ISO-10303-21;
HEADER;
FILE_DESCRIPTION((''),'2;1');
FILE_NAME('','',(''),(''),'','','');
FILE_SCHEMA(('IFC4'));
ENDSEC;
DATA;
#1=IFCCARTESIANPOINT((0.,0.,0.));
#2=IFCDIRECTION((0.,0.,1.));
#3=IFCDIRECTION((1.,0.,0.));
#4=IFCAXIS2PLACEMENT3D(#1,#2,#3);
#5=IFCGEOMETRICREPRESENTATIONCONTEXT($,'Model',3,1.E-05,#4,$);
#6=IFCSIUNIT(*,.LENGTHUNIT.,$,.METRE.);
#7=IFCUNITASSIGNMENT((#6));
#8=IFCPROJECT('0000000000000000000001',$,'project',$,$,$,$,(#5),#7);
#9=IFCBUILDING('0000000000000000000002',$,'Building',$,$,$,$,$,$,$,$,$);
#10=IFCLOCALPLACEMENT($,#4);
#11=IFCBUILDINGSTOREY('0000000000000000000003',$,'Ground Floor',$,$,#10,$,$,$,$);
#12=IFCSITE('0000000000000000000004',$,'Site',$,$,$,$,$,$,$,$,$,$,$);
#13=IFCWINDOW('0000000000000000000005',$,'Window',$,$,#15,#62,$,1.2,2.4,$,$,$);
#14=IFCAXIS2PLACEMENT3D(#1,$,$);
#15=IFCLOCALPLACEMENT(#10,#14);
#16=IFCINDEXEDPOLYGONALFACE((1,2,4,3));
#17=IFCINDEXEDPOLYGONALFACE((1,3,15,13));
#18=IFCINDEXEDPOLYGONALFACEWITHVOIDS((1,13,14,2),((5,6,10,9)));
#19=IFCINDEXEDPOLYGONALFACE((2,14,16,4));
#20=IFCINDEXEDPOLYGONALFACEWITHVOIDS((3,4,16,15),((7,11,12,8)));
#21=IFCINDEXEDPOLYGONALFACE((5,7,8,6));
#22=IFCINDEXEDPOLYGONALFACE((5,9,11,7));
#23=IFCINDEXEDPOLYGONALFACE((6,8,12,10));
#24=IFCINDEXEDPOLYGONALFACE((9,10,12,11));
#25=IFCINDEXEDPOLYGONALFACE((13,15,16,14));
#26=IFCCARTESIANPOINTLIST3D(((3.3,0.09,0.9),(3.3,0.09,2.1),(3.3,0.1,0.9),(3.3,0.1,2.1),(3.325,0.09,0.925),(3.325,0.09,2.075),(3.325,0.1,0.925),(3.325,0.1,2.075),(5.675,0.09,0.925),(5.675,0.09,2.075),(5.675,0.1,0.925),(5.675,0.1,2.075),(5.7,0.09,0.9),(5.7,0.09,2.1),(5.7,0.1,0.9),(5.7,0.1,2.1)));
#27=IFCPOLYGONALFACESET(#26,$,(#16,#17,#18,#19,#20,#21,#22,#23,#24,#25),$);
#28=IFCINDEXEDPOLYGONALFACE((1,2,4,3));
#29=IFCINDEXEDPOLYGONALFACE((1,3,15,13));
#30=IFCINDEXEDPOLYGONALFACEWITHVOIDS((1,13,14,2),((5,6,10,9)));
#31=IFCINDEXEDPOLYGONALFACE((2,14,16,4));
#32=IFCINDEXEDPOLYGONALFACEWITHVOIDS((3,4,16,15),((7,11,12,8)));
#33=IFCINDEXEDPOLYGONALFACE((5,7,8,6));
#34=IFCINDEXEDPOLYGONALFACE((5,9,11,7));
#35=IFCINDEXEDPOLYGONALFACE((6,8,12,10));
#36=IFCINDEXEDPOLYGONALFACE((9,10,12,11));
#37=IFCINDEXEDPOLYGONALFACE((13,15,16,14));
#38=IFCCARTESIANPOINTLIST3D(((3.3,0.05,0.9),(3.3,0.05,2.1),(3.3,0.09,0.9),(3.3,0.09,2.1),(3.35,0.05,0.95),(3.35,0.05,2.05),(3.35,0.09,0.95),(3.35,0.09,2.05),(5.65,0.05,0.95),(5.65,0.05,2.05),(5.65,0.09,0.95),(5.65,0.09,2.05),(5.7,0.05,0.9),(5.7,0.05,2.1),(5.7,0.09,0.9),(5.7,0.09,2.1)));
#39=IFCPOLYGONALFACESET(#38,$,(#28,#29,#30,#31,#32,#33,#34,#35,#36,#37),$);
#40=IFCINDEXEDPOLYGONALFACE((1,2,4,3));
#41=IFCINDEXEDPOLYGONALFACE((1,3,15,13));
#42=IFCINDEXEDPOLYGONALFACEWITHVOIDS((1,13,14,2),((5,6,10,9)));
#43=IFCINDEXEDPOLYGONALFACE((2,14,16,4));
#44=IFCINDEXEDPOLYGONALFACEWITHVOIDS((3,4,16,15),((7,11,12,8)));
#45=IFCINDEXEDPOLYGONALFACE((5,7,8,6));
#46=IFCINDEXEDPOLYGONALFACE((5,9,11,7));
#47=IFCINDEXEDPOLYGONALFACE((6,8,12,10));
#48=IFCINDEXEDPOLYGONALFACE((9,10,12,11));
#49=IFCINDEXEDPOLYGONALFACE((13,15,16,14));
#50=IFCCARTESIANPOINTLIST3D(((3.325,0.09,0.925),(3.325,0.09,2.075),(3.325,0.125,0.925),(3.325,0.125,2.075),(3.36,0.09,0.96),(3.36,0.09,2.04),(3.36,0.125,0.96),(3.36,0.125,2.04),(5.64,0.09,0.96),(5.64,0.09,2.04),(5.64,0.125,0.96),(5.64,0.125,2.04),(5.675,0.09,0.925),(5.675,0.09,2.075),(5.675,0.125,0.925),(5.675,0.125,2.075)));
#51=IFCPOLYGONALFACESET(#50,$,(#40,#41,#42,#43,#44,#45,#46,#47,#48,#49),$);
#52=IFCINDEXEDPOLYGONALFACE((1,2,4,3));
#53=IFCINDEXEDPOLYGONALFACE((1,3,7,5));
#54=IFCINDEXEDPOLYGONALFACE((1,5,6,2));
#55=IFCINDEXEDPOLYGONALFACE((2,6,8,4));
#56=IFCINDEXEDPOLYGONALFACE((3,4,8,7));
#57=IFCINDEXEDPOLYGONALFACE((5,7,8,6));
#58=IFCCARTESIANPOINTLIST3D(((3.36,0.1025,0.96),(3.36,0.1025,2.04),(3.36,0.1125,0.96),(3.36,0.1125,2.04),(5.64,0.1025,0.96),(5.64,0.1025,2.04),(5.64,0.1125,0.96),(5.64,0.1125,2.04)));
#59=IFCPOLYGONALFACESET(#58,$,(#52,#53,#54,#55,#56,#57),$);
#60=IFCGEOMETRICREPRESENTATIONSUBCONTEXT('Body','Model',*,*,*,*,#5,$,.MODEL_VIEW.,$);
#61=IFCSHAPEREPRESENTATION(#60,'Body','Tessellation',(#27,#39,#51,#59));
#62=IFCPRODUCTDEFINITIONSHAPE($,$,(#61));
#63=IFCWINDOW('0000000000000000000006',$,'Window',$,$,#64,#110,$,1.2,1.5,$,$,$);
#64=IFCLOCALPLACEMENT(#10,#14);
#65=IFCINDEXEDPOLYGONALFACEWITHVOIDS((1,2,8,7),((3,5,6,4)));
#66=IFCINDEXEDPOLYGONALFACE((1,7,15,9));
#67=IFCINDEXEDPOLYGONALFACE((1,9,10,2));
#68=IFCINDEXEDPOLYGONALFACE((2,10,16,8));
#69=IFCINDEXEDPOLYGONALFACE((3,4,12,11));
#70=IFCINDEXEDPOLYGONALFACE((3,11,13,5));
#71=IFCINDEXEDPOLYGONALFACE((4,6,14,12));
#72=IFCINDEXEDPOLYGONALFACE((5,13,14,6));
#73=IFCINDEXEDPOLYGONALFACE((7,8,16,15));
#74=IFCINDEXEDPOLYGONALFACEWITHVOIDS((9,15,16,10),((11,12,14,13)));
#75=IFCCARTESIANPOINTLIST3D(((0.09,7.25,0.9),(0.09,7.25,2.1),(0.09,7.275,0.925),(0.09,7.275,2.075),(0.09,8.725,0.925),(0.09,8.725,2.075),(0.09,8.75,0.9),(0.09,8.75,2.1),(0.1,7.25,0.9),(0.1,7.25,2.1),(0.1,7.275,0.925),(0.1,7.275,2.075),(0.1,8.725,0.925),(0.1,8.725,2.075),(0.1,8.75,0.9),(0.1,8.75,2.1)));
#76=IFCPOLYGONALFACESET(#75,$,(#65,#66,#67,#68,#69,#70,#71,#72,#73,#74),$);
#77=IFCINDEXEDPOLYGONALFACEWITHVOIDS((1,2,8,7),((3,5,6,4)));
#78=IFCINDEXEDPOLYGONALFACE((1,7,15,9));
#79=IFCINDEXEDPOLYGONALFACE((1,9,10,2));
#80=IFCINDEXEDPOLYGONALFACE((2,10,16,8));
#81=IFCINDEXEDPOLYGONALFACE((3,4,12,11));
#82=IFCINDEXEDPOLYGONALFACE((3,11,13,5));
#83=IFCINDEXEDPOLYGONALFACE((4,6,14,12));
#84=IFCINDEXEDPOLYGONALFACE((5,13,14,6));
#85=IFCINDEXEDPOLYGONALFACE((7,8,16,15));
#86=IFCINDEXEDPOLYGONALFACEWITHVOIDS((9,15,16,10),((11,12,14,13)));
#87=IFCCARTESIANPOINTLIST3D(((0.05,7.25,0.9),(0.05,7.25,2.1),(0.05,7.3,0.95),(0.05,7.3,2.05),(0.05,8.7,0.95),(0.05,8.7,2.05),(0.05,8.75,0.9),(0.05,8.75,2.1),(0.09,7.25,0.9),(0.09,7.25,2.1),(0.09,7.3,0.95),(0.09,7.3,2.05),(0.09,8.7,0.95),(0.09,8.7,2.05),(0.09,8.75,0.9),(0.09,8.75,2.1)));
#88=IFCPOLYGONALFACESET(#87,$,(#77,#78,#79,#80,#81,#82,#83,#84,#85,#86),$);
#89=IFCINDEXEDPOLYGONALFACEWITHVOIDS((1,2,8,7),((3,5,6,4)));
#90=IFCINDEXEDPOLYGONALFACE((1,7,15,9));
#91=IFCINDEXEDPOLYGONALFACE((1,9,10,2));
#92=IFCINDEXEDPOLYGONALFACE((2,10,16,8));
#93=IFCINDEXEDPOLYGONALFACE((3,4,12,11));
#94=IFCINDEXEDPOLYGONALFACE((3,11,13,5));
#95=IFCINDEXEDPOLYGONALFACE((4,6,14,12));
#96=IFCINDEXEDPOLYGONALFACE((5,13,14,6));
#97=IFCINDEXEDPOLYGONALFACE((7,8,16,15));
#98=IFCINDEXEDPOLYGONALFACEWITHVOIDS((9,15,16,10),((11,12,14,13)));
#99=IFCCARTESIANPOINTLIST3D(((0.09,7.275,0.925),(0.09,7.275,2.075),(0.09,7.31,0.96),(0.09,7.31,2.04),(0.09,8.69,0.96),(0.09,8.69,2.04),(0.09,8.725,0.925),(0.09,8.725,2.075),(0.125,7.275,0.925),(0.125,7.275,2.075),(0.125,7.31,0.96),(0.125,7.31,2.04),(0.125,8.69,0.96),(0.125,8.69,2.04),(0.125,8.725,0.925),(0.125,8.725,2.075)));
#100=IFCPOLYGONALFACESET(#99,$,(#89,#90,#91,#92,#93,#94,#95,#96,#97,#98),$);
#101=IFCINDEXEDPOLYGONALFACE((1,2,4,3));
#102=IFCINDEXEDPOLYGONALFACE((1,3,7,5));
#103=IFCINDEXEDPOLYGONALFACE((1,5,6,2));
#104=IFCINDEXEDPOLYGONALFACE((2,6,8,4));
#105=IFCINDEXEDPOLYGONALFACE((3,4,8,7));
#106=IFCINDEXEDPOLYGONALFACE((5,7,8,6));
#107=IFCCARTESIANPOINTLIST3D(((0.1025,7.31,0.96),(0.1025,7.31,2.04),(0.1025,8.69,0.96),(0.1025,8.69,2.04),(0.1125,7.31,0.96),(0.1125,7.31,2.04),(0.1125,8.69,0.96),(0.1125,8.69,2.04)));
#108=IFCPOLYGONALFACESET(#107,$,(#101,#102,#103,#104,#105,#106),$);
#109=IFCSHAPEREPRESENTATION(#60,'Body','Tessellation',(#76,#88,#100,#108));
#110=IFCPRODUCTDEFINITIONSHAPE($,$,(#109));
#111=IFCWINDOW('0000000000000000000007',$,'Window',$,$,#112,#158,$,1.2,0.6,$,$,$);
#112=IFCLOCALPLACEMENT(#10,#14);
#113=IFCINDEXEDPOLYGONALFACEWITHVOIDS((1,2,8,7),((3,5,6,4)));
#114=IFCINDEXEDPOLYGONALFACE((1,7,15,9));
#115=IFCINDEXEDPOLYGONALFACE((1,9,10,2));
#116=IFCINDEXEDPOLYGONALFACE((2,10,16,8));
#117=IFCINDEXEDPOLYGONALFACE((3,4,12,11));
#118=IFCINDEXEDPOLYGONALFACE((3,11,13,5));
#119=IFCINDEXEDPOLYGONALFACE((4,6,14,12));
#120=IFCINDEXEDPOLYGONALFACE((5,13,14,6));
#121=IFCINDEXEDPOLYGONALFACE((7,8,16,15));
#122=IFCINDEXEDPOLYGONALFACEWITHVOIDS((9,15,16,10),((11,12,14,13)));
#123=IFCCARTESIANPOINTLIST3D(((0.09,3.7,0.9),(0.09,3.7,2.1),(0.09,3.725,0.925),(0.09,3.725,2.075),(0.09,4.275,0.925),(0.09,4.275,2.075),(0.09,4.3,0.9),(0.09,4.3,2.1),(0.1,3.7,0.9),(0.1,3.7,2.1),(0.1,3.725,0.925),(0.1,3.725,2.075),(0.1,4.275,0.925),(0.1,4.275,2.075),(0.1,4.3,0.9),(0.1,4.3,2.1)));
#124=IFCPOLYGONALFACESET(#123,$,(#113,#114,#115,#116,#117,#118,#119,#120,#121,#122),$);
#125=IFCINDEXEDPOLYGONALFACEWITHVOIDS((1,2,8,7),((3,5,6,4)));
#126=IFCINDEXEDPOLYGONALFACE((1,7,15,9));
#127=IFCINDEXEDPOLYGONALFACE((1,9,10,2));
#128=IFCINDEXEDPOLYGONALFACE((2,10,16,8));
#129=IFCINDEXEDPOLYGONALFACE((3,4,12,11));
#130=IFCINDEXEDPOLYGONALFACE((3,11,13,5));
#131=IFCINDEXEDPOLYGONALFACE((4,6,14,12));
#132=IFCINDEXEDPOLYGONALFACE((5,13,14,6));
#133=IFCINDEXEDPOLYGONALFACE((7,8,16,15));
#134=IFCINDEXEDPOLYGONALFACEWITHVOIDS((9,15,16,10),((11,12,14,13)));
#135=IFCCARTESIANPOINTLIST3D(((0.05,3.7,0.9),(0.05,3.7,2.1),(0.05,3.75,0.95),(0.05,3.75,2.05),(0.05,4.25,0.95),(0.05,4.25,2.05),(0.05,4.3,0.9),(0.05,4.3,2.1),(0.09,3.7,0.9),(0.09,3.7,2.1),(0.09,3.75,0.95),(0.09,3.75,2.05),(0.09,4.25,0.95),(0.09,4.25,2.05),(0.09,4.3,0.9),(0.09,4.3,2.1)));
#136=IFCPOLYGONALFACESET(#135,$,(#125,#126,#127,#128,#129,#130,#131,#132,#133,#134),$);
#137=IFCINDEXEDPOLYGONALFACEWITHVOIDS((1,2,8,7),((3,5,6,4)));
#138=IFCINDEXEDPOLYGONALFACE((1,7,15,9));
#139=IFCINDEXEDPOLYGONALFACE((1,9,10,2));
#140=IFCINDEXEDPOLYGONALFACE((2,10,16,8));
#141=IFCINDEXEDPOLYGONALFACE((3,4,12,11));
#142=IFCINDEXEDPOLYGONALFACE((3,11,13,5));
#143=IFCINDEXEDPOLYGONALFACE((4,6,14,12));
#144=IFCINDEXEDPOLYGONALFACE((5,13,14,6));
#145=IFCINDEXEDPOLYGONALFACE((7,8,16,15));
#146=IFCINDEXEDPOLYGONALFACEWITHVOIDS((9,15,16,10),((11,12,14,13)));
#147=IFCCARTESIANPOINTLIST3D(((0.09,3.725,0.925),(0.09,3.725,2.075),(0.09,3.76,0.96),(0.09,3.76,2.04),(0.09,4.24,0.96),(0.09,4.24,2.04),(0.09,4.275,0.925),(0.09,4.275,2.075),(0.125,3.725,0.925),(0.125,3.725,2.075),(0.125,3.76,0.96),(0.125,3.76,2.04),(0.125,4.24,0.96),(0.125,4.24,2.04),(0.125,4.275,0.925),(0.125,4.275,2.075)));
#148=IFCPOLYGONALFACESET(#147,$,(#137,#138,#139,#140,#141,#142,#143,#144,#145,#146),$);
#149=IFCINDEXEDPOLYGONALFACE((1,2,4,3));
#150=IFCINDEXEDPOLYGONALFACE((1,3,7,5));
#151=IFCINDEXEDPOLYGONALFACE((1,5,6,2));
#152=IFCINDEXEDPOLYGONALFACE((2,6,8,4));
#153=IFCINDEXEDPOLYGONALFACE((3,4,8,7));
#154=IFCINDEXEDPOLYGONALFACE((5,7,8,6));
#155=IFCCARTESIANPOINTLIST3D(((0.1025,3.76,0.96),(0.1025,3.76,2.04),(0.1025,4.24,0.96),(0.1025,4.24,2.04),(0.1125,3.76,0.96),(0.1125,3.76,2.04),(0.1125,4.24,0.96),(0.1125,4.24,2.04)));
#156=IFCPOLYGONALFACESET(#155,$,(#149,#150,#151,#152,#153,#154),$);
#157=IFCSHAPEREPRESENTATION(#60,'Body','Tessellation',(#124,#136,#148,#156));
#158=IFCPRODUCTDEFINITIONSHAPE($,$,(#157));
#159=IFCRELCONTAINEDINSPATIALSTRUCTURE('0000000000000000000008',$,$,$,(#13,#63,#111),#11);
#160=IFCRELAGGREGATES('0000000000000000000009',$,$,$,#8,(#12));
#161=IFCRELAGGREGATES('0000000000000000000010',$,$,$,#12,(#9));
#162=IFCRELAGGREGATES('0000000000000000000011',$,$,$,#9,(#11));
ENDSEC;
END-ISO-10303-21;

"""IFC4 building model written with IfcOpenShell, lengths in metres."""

from ifc_helpers import new_model, si_unit, frame, origin_with_axes, place, context, subcontext, project, spatial, line, indexed_curve, outline, extrude, element, save


model = new_model("IFC4")

# Units and contexts
model_context = context("Model", 3, precision=1e-05, world=origin_with_axes())
body_context = subcontext(model_context, "Body", "Model", "MODEL_VIEW")
ifc_project = project(units=[si_unit("LENGTHUNIT", "METRE")], contexts=[model_context])

# Site, building, storey
site = spatial("IfcSite", under=ifc_project, Name="Site")
building = spatial("IfcBuilding", under=site, Name="Building")
storey_placement = place(None, origin_with_axes())
storey = spatial("IfcBuildingStorey", under=building, at=storey_placement, Name="Ground Floor")

# Windows
window_1_placement = place(storey_placement, frame((3.3, 0.0, 0.9), z_axis=(0.0, 0.0, 1.0), x_axis=(1.0, 0.0, 0.0)))
element("IfcWindow", 1, at=window_1_placement, inside=storey, Name="Window", OverallHeight=1.2, OverallWidth=2.4, context=body_context, shape_type="SweptSolid", body=[
    extrude(outline(indexed_curve([(0.0, 0.0), (2.4, 0.0), (2.4, 1.2), (0.0, 1.2)], segments=[line(1, 2, 3, 4, 1)]), holes=[indexed_curve([(0.025, 0.025), (2.375, 0.025), (2.375, 1.175), (0.025, 1.175)], segments=[line(1, 2, 3, 4, 1)])]), frame((0.0, 0.09, 0.0), z_axis=(0.0, -1.0, 0.0), x_axis=(1.0, 0.0, 0.0)), (0.0, 0.0, -1.0), 0.01),
    extrude(outline(indexed_curve([(0.0, 0.0), (2.4, 0.0), (2.4, 1.2), (0.0, 1.2)], segments=[line(1, 2, 3, 4, 1)]), holes=[indexed_curve([(0.05, 0.05), (2.35, 0.05), (2.35, 1.15), (0.05, 1.15)], segments=[line(1, 2, 3, 4, 1)])]), frame((0.0, 0.05, 0.0), z_axis=(0.0, -1.0, 0.0), x_axis=(1.0, 0.0, 0.0)), (0.0, 0.0, -1.0), 0.04),
    extrude(outline(indexed_curve([(0.0, 0.0), (2.35, 0.0), (2.35, 1.15), (0.0, 1.15)], segments=[line(1, 2, 3, 4, 1)]), holes=[indexed_curve([(0.035, 0.035), (2.315, 0.035), (2.315, 1.115), (0.035, 1.115)], segments=[line(1, 2, 3, 4, 1)])]), frame((0.025, 0.09, 0.025), z_axis=(0.0, -1.0, 0.0), x_axis=(1.0, 0.0, 0.0)), (0.0, 0.0, -1.0), 0.035),
    extrude(outline(indexed_curve([(0.035, 0.035), (2.315, 0.035), (2.315, 1.115), (0.035, 1.115)], segments=[line(1, 2, 3, 4, 1)])), frame((0.025, 0.1025, 0.025), z_axis=(0.0, -1.0, 0.0), x_axis=(1.0, 0.0, 0.0)), (0.0, 0.0, -1.0), 0.01),
])
window_2_placement = place(storey_placement, frame((0.0, 8.75, 0.9), z_axis=(0.0, 0.0, 1.0), x_axis=(0.0, -1.0, 0.0)))
element("IfcWindow", 2, at=window_2_placement, inside=storey, Name="Window", OverallHeight=1.2, OverallWidth=1.5, context=body_context, shape_type="SweptSolid", body=[
    extrude(outline(indexed_curve([(0.0, 0.0), (1.5, 0.0), (1.5, 1.2), (0.0, 1.2)], segments=[line(1, 2, 3, 4, 1)]), holes=[indexed_curve([(0.025, 0.025), (1.475, 0.025), (1.475, 1.175), (0.025, 1.175)], segments=[line(1, 2, 3, 4, 1)])]), frame((0.0, 0.09, 0.0), z_axis=(0.0, -1.0, 0.0), x_axis=(1.0, 0.0, 0.0)), (0.0, 0.0, -1.0), 0.01),
    extrude(outline(indexed_curve([(0.0, 0.0), (1.5, 0.0), (1.5, 1.2), (0.0, 1.2)], segments=[line(1, 2, 3, 4, 1)]), holes=[indexed_curve([(0.05, 0.05), (1.45, 0.05), (1.45, 1.15), (0.05, 1.15)], segments=[line(1, 2, 3, 4, 1)])]), frame((0.0, 0.05, 0.0), z_axis=(0.0, -1.0, 0.0), x_axis=(1.0, 0.0, 0.0)), (0.0, 0.0, -1.0), 0.04),
    extrude(outline(indexed_curve([(0.0, 0.0), (1.45, 0.0), (1.45, 1.15), (0.0, 1.15)], segments=[line(1, 2, 3, 4, 1)]), holes=[indexed_curve([(0.035, 0.035), (1.415, 0.035), (1.415, 1.115), (0.035, 1.115)], segments=[line(1, 2, 3, 4, 1)])]), frame((0.025, 0.09, 0.025), z_axis=(0.0, -1.0, 0.0), x_axis=(1.0, 0.0, 0.0)), (0.0, 0.0, -1.0), 0.035),
    extrude(outline(indexed_curve([(0.035, 0.035), (1.415, 0.035), (1.415, 1.115), (0.035, 1.115)], segments=[line(1, 2, 3, 4, 1)])), frame((0.025, 0.1025, 0.025), z_axis=(0.0, -1.0, 0.0), x_axis=(1.0, 0.0, 0.0)), (0.0, 0.0, -1.0), 0.01),
])
window_3_placement = place(storey_placement, frame((0.0, 4.3, 0.9), z_axis=(0.0, 0.0, 1.0), x_axis=(0.0, -1.0, 0.0)))
element("IfcWindow", 3, at=window_3_placement, inside=storey, Name="Window", OverallHeight=1.2, OverallWidth=0.6, context=body_context, shape_type="SweptSolid", body=[
    extrude(outline(indexed_curve([(0.0, 0.0), (0.6, 0.0), (0.6, 1.2), (0.0, 1.2)], segments=[line(1, 2, 3, 4, 1)]), holes=[indexed_curve([(0.025, 0.025), (0.575, 0.025), (0.575, 1.175), (0.025, 1.175)], segments=[line(1, 2, 3, 4, 1)])]), frame((0.0, 0.09, 0.0), z_axis=(0.0, -1.0, 0.0), x_axis=(1.0, 0.0, 0.0)), (0.0, 0.0, -1.0), 0.01),
    extrude(outline(indexed_curve([(0.0, 0.0), (0.6, 0.0), (0.6, 1.2), (0.0, 1.2)], segments=[line(1, 2, 3, 4, 1)]), holes=[indexed_curve([(0.05, 0.05), (0.55, 0.05), (0.55, 1.15), (0.05, 1.15)], segments=[line(1, 2, 3, 4, 1)])]), frame((0.0, 0.05, 0.0), z_axis=(0.0, -1.0, 0.0), x_axis=(1.0, 0.0, 0.0)), (0.0, 0.0, -1.0), 0.04),
    extrude(outline(indexed_curve([(0.0, 0.0), (0.55, 0.0), (0.55, 1.15), (0.0, 1.15)], segments=[line(1, 2, 3, 4, 1)]), holes=[indexed_curve([(0.035, 0.035), (0.515, 0.035), (0.515, 1.115), (0.035, 1.115)], segments=[line(1, 2, 3, 4, 1)])]), frame((0.025, 0.09, 0.025), z_axis=(0.0, -1.0, 0.0), x_axis=(1.0, 0.0, 0.0)), (0.0, 0.0, -1.0), 0.035),
    extrude(outline(indexed_curve([(0.035, 0.035), (0.515, 0.035), (0.515, 1.115), (0.035, 1.115)], segments=[line(1, 2, 3, 4, 1)])), frame((0.025, 0.1025, 0.025), z_axis=(0.0, -1.0, 0.0), x_axis=(1.0, 0.0, 0.0)), (0.0, 0.0, -1.0), 0.01),
])

save(model, "model.ifc")
